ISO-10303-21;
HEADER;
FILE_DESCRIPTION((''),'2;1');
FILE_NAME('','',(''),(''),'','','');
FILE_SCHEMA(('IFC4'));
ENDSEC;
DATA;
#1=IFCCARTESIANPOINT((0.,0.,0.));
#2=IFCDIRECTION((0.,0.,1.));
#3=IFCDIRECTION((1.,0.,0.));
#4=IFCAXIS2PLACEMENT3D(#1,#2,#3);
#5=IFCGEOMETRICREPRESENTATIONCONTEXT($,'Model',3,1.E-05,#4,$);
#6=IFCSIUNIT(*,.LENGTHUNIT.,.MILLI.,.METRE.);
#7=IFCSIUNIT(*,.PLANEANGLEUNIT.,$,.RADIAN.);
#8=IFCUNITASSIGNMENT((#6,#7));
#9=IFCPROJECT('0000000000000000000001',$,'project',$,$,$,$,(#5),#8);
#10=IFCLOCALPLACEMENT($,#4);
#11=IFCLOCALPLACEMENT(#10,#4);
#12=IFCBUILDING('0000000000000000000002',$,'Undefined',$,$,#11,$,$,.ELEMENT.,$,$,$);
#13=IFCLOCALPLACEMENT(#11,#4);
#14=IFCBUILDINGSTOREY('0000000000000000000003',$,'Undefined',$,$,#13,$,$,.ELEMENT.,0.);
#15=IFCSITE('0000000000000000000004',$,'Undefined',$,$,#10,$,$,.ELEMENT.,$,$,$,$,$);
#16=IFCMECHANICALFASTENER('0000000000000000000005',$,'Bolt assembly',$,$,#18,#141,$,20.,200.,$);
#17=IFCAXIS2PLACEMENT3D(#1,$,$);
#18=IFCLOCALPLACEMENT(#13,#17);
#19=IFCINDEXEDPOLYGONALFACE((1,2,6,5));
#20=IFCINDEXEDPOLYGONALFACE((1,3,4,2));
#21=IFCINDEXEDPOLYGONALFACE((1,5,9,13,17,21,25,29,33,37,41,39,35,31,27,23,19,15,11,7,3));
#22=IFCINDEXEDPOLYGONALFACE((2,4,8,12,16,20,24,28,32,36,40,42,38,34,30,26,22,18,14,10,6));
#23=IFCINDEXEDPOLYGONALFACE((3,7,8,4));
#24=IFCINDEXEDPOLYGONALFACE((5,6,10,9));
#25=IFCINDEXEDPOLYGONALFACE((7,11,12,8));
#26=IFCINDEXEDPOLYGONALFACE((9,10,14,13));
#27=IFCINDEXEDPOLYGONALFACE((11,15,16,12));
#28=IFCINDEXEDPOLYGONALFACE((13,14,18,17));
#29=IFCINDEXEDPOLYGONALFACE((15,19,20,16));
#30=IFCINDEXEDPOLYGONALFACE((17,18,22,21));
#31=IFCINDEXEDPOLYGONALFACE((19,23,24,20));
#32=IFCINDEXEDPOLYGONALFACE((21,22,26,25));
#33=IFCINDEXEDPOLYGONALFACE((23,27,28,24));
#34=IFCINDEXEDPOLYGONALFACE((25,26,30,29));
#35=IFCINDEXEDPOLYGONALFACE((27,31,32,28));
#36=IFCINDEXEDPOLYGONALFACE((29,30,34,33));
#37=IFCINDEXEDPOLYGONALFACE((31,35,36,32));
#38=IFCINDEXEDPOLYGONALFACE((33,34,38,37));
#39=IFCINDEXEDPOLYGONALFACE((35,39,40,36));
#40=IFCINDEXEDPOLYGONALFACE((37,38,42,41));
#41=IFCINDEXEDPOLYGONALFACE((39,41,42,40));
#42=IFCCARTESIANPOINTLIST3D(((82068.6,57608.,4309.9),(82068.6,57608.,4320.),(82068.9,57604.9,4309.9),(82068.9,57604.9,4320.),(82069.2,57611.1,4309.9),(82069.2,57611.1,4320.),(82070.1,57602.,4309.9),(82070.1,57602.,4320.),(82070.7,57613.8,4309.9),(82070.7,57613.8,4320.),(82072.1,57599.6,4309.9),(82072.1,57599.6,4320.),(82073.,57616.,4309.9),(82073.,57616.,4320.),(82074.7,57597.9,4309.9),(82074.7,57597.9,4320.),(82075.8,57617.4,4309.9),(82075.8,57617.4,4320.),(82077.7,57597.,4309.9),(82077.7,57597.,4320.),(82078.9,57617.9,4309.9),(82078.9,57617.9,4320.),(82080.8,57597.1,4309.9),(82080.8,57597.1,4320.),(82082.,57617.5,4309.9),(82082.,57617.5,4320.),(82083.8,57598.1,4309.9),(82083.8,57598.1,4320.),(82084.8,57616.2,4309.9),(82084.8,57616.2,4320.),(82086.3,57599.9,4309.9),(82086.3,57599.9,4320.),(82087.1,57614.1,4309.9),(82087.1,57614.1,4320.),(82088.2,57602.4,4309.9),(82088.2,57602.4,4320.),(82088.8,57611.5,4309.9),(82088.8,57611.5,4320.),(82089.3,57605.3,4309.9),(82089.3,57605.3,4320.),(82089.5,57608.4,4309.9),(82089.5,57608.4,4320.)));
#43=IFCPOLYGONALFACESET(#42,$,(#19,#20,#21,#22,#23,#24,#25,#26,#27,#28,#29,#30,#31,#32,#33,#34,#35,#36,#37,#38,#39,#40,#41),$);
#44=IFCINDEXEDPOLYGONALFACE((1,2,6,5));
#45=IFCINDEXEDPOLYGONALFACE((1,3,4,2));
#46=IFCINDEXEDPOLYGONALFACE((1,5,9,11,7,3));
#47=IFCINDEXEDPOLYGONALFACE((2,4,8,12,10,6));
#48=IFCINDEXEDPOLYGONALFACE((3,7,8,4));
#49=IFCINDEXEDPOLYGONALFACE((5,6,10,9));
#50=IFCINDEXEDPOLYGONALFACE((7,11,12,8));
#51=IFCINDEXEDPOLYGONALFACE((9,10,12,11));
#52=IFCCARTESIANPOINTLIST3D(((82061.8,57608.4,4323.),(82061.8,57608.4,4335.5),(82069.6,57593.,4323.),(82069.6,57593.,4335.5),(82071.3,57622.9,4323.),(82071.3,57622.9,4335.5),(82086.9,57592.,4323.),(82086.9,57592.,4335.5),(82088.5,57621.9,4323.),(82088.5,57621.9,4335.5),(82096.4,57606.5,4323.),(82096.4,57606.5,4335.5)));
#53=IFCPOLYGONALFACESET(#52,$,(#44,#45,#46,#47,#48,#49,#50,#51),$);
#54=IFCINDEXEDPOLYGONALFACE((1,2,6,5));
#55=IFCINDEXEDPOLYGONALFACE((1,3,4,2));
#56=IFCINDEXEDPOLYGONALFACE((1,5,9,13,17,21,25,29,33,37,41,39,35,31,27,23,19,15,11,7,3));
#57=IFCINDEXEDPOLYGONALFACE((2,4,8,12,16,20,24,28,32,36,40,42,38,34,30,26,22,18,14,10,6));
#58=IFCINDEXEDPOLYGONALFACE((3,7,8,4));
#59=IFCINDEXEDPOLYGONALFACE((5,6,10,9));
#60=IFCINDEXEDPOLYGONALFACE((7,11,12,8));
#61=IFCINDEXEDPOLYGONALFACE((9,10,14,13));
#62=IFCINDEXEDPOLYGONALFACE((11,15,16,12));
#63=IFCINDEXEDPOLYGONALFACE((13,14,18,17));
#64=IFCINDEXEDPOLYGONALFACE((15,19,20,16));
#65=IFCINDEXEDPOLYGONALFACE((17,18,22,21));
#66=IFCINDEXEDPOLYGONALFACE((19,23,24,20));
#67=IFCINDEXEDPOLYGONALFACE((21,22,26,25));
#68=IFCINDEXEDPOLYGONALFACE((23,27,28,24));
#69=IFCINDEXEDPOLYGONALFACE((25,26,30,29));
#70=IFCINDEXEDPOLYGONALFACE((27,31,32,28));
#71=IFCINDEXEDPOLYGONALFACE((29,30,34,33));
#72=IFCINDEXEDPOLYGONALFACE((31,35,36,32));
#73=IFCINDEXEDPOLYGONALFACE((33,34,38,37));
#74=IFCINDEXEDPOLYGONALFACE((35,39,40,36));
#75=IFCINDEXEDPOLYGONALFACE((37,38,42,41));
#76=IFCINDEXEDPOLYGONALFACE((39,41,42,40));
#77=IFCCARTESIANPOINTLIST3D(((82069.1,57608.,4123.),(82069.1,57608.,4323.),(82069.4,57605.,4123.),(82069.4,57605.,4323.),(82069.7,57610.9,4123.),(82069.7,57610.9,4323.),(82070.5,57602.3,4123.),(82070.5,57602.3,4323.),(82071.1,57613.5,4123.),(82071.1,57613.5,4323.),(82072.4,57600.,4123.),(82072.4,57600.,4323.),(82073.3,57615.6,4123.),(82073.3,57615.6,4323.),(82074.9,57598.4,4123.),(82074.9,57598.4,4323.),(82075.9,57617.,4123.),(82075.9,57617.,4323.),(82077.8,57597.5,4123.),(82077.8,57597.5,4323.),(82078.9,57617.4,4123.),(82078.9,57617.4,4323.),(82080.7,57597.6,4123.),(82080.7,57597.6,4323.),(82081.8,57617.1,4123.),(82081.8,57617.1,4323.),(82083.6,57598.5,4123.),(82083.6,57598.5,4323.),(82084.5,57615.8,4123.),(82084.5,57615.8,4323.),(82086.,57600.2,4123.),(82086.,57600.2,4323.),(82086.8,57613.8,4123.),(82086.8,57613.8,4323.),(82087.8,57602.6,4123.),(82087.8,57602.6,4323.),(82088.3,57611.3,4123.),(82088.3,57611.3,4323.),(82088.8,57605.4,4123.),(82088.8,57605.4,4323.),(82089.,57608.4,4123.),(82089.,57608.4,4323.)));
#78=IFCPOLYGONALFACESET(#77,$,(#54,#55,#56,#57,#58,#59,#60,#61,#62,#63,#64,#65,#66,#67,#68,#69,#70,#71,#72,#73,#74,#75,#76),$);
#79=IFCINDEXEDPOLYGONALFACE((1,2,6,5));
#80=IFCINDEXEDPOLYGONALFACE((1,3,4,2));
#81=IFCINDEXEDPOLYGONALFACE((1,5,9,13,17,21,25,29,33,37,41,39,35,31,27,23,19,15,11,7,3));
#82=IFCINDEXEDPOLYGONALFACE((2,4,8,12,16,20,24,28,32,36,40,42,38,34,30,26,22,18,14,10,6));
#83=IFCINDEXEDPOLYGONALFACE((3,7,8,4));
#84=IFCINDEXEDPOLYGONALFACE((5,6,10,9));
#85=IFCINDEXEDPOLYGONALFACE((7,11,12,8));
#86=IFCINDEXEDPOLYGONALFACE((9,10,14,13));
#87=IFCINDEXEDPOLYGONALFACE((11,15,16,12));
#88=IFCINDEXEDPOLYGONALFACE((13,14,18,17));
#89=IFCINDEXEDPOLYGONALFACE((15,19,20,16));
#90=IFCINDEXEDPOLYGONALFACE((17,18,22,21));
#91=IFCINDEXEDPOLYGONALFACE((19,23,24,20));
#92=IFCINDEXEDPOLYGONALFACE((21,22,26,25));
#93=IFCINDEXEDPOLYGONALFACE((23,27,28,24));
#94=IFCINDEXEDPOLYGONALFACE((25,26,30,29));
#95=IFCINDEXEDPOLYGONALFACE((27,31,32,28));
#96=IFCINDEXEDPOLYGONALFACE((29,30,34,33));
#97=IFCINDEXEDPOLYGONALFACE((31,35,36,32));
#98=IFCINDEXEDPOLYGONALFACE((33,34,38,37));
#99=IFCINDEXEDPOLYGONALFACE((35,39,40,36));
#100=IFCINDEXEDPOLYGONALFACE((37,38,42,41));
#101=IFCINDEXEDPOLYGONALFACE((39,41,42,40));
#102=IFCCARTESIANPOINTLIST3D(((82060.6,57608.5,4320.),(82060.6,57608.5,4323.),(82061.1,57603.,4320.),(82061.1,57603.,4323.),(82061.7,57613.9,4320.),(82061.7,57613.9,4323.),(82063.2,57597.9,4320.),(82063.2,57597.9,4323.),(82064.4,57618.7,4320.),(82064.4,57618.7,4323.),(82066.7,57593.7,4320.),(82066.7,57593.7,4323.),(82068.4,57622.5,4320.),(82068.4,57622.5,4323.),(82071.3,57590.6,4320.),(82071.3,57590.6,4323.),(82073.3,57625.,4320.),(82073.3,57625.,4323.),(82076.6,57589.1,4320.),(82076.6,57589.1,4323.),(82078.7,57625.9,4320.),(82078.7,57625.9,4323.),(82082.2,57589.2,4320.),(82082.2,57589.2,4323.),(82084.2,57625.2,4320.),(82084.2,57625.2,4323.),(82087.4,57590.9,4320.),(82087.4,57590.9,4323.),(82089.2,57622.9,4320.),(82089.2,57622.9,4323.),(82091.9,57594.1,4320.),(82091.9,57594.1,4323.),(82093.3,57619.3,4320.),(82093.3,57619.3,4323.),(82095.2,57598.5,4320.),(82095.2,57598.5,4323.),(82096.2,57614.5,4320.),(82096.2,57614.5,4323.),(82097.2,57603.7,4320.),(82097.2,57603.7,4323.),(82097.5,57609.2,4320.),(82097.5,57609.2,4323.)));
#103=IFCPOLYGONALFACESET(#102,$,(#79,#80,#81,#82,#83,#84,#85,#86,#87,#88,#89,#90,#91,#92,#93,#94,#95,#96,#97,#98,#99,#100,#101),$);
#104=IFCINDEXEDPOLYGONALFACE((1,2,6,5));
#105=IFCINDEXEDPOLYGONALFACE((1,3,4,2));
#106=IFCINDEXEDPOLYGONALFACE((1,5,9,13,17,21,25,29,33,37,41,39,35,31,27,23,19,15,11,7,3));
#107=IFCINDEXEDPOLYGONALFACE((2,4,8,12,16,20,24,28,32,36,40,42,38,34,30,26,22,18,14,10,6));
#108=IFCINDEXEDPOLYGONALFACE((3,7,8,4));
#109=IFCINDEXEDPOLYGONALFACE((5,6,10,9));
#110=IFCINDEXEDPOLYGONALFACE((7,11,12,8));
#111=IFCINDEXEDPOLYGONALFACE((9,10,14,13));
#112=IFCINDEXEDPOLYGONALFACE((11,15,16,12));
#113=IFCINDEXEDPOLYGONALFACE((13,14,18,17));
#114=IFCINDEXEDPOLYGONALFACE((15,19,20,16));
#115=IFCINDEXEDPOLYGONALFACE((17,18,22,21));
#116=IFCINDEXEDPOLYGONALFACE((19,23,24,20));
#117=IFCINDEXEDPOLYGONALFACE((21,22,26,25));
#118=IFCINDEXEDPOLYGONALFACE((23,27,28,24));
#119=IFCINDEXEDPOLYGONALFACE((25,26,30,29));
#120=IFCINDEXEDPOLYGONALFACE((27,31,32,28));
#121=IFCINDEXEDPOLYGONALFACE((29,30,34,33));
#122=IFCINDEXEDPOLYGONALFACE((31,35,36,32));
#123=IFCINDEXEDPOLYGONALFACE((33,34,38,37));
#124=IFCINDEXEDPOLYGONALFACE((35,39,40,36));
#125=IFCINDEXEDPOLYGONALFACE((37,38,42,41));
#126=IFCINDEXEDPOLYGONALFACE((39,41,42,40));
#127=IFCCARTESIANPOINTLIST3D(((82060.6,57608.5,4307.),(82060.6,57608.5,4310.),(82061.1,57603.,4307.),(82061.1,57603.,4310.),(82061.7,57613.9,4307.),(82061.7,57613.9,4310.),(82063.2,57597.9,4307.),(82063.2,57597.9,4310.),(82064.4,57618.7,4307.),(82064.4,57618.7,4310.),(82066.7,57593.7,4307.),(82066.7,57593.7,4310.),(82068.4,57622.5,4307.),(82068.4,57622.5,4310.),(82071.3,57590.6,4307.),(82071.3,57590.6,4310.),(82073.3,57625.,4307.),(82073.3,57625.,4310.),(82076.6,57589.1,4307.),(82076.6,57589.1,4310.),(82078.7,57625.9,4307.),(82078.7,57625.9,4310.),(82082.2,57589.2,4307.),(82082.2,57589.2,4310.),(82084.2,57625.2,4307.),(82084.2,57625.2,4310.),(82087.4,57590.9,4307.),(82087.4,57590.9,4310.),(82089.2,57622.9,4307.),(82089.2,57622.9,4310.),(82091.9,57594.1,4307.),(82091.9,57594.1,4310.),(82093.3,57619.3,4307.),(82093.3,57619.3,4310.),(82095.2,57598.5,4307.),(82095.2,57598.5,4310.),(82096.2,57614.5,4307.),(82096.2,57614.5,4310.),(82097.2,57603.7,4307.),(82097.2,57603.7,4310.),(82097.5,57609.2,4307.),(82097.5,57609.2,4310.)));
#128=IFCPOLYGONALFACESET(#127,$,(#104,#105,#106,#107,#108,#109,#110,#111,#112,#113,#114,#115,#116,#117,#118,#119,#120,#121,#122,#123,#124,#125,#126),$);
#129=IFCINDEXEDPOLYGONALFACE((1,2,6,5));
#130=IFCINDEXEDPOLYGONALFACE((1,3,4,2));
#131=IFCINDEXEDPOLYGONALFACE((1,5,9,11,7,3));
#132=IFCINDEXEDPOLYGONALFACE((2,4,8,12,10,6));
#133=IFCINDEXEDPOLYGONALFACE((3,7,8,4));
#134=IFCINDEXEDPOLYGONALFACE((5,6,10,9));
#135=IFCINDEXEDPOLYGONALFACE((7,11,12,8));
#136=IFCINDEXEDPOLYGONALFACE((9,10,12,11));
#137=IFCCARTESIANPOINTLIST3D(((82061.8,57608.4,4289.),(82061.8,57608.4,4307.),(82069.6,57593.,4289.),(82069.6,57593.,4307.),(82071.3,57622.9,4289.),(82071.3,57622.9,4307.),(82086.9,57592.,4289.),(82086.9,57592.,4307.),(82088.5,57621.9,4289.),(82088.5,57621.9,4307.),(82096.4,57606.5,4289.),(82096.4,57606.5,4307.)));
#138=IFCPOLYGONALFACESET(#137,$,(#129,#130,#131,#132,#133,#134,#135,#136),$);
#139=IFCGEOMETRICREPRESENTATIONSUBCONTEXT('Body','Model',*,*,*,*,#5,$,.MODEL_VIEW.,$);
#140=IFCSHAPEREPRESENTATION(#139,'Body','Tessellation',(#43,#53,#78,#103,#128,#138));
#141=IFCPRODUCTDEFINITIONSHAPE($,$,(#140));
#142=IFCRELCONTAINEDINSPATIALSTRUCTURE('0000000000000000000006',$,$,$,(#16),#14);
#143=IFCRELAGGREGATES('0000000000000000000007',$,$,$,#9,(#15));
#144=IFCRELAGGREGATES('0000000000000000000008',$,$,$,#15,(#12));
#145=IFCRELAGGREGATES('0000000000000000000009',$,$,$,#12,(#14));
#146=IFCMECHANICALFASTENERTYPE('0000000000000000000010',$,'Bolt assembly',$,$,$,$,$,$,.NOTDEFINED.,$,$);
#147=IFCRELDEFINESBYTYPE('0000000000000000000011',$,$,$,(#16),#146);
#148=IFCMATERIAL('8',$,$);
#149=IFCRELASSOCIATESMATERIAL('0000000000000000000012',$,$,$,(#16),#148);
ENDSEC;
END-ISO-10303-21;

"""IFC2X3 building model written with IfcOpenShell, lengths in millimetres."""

from ifc_helpers import new_model, si_unit, frame, origin_with_axes, origin_2d_with_axis, place, context, subcontext, project, spatial, polyline, circle, outline, extrude, source, transform, mapped, material, type_object, element, save


model = new_model("IFC2X3")

# Units and contexts
model_context = context("Model", 3, precision=1e-05, world=origin_with_axes())
body_context = subcontext(model_context, "Body", "Model", "MODEL_VIEW")
ifc_project = project(units=[si_unit("LENGTHUNIT", "METRE", prefix="MILLI"), si_unit("PLANEANGLEUNIT", "RADIAN")], contexts=[model_context])

# Site, building, storey
site_placement = place(None, origin_with_axes())
site = spatial("IfcSite", under=ifc_project, at=site_placement, Name="Undefined", CompositionType="ELEMENT")
building_placement = place(site_placement, origin_with_axes())
building = spatial("IfcBuilding", under=site, at=building_placement, Name="Undefined", CompositionType="ELEMENT")
storey_placement = place(building_placement, origin_with_axes())
storey = spatial("IfcBuildingStorey", under=building, at=storey_placement, Name="Undefined", CompositionType="ELEMENT", Elevation=0.0)

# Mechanical fastener
ifc_material_1 = material(Name="8")
mechanical_fastener_type = type_object("IfcMechanicalFastenerType", Name="Bolt assembly")
shared_shape_1 = source(origin_with_axes(), body_context, "Body", "SweptSolid", [
    extrude(circle(Radius=10.5, at=origin_2d_with_axis()), frame((0.0, 0.0, 0.0), z_axis=(0.0, 1.0, 0.0), x_axis=(1.0, 0.0, 0.0)), (0.0, 0.0, 1.0), 10.1),
    extrude(outline(polyline([(17.3, 0.0), (8.7, 15.0), (-8.7, 15.0), (-17.3, 0.0), (-8.7, -15.0), (8.7, -15.0), (17.3, 0.0)])), frame((0.0, -15.5, 0.0), z_axis=(0.0, 1.0, 0.0), x_axis=(1.0, 0.0, 0.0)), (0.0, 0.0, 1.0), 12.5),
    extrude(circle(Radius=10.0, at=origin_2d_with_axis()), frame((0.0, -3.0, 0.0), z_axis=(0.0, 1.0, 0.0), x_axis=(1.0, 0.0, 0.0)), (0.0, 0.0, 1.0), 200.0),
    extrude(circle(Radius=18.5, at=origin_2d_with_axis()), frame((0.0, -3.0, 0.0), z_axis=(0.0, 1.0, 0.0), x_axis=(1.0, 0.0, 0.0)), (0.0, 0.0, 1.0), 3.0),
    extrude(circle(Radius=18.5, at=origin_2d_with_axis()), frame((0.0, 10.0, 0.0), z_axis=(0.0, 1.0, 0.0), x_axis=(1.0, 0.0, 0.0)), (0.0, 0.0, 1.0), 3.0),
    extrude(outline(polyline([(17.3, 0.0), (8.7, 15.0), (-8.7, 15.0), (-17.3, 0.0), (-8.7, -15.0), (8.7, -15.0), (17.3, 0.0)])), frame((0.0, 13.0, 0.0), z_axis=(0.0, 1.0, 0.0), x_axis=(1.0, 0.0, 0.0)), (0.0, 0.0, 1.0), 18.0),
])
for number, where, z_axis, x_axis, name in (
    (1, (82079.1, 57607.5, 4320.0), (0.892799, 0.450455, 0.0), (0.450455, -0.892799, 0.0), "Bolt assembly"),
):
    element("IfcMechanicalFastener", number, at=place(storey_placement, frame(where, z_axis=z_axis, x_axis=x_axis)), inside=storey, type_object=mechanical_fastener_type, material=ifc_material_1, Name=name, NominalDiameter=20.0, NominalLength=200.0, context=body_context, shape_type="MappedRepresentation", body=[
        mapped(shared_shape_1, transform((0.0, 0.0, 0.0))),
    ])

save(model, "model.ifc")
